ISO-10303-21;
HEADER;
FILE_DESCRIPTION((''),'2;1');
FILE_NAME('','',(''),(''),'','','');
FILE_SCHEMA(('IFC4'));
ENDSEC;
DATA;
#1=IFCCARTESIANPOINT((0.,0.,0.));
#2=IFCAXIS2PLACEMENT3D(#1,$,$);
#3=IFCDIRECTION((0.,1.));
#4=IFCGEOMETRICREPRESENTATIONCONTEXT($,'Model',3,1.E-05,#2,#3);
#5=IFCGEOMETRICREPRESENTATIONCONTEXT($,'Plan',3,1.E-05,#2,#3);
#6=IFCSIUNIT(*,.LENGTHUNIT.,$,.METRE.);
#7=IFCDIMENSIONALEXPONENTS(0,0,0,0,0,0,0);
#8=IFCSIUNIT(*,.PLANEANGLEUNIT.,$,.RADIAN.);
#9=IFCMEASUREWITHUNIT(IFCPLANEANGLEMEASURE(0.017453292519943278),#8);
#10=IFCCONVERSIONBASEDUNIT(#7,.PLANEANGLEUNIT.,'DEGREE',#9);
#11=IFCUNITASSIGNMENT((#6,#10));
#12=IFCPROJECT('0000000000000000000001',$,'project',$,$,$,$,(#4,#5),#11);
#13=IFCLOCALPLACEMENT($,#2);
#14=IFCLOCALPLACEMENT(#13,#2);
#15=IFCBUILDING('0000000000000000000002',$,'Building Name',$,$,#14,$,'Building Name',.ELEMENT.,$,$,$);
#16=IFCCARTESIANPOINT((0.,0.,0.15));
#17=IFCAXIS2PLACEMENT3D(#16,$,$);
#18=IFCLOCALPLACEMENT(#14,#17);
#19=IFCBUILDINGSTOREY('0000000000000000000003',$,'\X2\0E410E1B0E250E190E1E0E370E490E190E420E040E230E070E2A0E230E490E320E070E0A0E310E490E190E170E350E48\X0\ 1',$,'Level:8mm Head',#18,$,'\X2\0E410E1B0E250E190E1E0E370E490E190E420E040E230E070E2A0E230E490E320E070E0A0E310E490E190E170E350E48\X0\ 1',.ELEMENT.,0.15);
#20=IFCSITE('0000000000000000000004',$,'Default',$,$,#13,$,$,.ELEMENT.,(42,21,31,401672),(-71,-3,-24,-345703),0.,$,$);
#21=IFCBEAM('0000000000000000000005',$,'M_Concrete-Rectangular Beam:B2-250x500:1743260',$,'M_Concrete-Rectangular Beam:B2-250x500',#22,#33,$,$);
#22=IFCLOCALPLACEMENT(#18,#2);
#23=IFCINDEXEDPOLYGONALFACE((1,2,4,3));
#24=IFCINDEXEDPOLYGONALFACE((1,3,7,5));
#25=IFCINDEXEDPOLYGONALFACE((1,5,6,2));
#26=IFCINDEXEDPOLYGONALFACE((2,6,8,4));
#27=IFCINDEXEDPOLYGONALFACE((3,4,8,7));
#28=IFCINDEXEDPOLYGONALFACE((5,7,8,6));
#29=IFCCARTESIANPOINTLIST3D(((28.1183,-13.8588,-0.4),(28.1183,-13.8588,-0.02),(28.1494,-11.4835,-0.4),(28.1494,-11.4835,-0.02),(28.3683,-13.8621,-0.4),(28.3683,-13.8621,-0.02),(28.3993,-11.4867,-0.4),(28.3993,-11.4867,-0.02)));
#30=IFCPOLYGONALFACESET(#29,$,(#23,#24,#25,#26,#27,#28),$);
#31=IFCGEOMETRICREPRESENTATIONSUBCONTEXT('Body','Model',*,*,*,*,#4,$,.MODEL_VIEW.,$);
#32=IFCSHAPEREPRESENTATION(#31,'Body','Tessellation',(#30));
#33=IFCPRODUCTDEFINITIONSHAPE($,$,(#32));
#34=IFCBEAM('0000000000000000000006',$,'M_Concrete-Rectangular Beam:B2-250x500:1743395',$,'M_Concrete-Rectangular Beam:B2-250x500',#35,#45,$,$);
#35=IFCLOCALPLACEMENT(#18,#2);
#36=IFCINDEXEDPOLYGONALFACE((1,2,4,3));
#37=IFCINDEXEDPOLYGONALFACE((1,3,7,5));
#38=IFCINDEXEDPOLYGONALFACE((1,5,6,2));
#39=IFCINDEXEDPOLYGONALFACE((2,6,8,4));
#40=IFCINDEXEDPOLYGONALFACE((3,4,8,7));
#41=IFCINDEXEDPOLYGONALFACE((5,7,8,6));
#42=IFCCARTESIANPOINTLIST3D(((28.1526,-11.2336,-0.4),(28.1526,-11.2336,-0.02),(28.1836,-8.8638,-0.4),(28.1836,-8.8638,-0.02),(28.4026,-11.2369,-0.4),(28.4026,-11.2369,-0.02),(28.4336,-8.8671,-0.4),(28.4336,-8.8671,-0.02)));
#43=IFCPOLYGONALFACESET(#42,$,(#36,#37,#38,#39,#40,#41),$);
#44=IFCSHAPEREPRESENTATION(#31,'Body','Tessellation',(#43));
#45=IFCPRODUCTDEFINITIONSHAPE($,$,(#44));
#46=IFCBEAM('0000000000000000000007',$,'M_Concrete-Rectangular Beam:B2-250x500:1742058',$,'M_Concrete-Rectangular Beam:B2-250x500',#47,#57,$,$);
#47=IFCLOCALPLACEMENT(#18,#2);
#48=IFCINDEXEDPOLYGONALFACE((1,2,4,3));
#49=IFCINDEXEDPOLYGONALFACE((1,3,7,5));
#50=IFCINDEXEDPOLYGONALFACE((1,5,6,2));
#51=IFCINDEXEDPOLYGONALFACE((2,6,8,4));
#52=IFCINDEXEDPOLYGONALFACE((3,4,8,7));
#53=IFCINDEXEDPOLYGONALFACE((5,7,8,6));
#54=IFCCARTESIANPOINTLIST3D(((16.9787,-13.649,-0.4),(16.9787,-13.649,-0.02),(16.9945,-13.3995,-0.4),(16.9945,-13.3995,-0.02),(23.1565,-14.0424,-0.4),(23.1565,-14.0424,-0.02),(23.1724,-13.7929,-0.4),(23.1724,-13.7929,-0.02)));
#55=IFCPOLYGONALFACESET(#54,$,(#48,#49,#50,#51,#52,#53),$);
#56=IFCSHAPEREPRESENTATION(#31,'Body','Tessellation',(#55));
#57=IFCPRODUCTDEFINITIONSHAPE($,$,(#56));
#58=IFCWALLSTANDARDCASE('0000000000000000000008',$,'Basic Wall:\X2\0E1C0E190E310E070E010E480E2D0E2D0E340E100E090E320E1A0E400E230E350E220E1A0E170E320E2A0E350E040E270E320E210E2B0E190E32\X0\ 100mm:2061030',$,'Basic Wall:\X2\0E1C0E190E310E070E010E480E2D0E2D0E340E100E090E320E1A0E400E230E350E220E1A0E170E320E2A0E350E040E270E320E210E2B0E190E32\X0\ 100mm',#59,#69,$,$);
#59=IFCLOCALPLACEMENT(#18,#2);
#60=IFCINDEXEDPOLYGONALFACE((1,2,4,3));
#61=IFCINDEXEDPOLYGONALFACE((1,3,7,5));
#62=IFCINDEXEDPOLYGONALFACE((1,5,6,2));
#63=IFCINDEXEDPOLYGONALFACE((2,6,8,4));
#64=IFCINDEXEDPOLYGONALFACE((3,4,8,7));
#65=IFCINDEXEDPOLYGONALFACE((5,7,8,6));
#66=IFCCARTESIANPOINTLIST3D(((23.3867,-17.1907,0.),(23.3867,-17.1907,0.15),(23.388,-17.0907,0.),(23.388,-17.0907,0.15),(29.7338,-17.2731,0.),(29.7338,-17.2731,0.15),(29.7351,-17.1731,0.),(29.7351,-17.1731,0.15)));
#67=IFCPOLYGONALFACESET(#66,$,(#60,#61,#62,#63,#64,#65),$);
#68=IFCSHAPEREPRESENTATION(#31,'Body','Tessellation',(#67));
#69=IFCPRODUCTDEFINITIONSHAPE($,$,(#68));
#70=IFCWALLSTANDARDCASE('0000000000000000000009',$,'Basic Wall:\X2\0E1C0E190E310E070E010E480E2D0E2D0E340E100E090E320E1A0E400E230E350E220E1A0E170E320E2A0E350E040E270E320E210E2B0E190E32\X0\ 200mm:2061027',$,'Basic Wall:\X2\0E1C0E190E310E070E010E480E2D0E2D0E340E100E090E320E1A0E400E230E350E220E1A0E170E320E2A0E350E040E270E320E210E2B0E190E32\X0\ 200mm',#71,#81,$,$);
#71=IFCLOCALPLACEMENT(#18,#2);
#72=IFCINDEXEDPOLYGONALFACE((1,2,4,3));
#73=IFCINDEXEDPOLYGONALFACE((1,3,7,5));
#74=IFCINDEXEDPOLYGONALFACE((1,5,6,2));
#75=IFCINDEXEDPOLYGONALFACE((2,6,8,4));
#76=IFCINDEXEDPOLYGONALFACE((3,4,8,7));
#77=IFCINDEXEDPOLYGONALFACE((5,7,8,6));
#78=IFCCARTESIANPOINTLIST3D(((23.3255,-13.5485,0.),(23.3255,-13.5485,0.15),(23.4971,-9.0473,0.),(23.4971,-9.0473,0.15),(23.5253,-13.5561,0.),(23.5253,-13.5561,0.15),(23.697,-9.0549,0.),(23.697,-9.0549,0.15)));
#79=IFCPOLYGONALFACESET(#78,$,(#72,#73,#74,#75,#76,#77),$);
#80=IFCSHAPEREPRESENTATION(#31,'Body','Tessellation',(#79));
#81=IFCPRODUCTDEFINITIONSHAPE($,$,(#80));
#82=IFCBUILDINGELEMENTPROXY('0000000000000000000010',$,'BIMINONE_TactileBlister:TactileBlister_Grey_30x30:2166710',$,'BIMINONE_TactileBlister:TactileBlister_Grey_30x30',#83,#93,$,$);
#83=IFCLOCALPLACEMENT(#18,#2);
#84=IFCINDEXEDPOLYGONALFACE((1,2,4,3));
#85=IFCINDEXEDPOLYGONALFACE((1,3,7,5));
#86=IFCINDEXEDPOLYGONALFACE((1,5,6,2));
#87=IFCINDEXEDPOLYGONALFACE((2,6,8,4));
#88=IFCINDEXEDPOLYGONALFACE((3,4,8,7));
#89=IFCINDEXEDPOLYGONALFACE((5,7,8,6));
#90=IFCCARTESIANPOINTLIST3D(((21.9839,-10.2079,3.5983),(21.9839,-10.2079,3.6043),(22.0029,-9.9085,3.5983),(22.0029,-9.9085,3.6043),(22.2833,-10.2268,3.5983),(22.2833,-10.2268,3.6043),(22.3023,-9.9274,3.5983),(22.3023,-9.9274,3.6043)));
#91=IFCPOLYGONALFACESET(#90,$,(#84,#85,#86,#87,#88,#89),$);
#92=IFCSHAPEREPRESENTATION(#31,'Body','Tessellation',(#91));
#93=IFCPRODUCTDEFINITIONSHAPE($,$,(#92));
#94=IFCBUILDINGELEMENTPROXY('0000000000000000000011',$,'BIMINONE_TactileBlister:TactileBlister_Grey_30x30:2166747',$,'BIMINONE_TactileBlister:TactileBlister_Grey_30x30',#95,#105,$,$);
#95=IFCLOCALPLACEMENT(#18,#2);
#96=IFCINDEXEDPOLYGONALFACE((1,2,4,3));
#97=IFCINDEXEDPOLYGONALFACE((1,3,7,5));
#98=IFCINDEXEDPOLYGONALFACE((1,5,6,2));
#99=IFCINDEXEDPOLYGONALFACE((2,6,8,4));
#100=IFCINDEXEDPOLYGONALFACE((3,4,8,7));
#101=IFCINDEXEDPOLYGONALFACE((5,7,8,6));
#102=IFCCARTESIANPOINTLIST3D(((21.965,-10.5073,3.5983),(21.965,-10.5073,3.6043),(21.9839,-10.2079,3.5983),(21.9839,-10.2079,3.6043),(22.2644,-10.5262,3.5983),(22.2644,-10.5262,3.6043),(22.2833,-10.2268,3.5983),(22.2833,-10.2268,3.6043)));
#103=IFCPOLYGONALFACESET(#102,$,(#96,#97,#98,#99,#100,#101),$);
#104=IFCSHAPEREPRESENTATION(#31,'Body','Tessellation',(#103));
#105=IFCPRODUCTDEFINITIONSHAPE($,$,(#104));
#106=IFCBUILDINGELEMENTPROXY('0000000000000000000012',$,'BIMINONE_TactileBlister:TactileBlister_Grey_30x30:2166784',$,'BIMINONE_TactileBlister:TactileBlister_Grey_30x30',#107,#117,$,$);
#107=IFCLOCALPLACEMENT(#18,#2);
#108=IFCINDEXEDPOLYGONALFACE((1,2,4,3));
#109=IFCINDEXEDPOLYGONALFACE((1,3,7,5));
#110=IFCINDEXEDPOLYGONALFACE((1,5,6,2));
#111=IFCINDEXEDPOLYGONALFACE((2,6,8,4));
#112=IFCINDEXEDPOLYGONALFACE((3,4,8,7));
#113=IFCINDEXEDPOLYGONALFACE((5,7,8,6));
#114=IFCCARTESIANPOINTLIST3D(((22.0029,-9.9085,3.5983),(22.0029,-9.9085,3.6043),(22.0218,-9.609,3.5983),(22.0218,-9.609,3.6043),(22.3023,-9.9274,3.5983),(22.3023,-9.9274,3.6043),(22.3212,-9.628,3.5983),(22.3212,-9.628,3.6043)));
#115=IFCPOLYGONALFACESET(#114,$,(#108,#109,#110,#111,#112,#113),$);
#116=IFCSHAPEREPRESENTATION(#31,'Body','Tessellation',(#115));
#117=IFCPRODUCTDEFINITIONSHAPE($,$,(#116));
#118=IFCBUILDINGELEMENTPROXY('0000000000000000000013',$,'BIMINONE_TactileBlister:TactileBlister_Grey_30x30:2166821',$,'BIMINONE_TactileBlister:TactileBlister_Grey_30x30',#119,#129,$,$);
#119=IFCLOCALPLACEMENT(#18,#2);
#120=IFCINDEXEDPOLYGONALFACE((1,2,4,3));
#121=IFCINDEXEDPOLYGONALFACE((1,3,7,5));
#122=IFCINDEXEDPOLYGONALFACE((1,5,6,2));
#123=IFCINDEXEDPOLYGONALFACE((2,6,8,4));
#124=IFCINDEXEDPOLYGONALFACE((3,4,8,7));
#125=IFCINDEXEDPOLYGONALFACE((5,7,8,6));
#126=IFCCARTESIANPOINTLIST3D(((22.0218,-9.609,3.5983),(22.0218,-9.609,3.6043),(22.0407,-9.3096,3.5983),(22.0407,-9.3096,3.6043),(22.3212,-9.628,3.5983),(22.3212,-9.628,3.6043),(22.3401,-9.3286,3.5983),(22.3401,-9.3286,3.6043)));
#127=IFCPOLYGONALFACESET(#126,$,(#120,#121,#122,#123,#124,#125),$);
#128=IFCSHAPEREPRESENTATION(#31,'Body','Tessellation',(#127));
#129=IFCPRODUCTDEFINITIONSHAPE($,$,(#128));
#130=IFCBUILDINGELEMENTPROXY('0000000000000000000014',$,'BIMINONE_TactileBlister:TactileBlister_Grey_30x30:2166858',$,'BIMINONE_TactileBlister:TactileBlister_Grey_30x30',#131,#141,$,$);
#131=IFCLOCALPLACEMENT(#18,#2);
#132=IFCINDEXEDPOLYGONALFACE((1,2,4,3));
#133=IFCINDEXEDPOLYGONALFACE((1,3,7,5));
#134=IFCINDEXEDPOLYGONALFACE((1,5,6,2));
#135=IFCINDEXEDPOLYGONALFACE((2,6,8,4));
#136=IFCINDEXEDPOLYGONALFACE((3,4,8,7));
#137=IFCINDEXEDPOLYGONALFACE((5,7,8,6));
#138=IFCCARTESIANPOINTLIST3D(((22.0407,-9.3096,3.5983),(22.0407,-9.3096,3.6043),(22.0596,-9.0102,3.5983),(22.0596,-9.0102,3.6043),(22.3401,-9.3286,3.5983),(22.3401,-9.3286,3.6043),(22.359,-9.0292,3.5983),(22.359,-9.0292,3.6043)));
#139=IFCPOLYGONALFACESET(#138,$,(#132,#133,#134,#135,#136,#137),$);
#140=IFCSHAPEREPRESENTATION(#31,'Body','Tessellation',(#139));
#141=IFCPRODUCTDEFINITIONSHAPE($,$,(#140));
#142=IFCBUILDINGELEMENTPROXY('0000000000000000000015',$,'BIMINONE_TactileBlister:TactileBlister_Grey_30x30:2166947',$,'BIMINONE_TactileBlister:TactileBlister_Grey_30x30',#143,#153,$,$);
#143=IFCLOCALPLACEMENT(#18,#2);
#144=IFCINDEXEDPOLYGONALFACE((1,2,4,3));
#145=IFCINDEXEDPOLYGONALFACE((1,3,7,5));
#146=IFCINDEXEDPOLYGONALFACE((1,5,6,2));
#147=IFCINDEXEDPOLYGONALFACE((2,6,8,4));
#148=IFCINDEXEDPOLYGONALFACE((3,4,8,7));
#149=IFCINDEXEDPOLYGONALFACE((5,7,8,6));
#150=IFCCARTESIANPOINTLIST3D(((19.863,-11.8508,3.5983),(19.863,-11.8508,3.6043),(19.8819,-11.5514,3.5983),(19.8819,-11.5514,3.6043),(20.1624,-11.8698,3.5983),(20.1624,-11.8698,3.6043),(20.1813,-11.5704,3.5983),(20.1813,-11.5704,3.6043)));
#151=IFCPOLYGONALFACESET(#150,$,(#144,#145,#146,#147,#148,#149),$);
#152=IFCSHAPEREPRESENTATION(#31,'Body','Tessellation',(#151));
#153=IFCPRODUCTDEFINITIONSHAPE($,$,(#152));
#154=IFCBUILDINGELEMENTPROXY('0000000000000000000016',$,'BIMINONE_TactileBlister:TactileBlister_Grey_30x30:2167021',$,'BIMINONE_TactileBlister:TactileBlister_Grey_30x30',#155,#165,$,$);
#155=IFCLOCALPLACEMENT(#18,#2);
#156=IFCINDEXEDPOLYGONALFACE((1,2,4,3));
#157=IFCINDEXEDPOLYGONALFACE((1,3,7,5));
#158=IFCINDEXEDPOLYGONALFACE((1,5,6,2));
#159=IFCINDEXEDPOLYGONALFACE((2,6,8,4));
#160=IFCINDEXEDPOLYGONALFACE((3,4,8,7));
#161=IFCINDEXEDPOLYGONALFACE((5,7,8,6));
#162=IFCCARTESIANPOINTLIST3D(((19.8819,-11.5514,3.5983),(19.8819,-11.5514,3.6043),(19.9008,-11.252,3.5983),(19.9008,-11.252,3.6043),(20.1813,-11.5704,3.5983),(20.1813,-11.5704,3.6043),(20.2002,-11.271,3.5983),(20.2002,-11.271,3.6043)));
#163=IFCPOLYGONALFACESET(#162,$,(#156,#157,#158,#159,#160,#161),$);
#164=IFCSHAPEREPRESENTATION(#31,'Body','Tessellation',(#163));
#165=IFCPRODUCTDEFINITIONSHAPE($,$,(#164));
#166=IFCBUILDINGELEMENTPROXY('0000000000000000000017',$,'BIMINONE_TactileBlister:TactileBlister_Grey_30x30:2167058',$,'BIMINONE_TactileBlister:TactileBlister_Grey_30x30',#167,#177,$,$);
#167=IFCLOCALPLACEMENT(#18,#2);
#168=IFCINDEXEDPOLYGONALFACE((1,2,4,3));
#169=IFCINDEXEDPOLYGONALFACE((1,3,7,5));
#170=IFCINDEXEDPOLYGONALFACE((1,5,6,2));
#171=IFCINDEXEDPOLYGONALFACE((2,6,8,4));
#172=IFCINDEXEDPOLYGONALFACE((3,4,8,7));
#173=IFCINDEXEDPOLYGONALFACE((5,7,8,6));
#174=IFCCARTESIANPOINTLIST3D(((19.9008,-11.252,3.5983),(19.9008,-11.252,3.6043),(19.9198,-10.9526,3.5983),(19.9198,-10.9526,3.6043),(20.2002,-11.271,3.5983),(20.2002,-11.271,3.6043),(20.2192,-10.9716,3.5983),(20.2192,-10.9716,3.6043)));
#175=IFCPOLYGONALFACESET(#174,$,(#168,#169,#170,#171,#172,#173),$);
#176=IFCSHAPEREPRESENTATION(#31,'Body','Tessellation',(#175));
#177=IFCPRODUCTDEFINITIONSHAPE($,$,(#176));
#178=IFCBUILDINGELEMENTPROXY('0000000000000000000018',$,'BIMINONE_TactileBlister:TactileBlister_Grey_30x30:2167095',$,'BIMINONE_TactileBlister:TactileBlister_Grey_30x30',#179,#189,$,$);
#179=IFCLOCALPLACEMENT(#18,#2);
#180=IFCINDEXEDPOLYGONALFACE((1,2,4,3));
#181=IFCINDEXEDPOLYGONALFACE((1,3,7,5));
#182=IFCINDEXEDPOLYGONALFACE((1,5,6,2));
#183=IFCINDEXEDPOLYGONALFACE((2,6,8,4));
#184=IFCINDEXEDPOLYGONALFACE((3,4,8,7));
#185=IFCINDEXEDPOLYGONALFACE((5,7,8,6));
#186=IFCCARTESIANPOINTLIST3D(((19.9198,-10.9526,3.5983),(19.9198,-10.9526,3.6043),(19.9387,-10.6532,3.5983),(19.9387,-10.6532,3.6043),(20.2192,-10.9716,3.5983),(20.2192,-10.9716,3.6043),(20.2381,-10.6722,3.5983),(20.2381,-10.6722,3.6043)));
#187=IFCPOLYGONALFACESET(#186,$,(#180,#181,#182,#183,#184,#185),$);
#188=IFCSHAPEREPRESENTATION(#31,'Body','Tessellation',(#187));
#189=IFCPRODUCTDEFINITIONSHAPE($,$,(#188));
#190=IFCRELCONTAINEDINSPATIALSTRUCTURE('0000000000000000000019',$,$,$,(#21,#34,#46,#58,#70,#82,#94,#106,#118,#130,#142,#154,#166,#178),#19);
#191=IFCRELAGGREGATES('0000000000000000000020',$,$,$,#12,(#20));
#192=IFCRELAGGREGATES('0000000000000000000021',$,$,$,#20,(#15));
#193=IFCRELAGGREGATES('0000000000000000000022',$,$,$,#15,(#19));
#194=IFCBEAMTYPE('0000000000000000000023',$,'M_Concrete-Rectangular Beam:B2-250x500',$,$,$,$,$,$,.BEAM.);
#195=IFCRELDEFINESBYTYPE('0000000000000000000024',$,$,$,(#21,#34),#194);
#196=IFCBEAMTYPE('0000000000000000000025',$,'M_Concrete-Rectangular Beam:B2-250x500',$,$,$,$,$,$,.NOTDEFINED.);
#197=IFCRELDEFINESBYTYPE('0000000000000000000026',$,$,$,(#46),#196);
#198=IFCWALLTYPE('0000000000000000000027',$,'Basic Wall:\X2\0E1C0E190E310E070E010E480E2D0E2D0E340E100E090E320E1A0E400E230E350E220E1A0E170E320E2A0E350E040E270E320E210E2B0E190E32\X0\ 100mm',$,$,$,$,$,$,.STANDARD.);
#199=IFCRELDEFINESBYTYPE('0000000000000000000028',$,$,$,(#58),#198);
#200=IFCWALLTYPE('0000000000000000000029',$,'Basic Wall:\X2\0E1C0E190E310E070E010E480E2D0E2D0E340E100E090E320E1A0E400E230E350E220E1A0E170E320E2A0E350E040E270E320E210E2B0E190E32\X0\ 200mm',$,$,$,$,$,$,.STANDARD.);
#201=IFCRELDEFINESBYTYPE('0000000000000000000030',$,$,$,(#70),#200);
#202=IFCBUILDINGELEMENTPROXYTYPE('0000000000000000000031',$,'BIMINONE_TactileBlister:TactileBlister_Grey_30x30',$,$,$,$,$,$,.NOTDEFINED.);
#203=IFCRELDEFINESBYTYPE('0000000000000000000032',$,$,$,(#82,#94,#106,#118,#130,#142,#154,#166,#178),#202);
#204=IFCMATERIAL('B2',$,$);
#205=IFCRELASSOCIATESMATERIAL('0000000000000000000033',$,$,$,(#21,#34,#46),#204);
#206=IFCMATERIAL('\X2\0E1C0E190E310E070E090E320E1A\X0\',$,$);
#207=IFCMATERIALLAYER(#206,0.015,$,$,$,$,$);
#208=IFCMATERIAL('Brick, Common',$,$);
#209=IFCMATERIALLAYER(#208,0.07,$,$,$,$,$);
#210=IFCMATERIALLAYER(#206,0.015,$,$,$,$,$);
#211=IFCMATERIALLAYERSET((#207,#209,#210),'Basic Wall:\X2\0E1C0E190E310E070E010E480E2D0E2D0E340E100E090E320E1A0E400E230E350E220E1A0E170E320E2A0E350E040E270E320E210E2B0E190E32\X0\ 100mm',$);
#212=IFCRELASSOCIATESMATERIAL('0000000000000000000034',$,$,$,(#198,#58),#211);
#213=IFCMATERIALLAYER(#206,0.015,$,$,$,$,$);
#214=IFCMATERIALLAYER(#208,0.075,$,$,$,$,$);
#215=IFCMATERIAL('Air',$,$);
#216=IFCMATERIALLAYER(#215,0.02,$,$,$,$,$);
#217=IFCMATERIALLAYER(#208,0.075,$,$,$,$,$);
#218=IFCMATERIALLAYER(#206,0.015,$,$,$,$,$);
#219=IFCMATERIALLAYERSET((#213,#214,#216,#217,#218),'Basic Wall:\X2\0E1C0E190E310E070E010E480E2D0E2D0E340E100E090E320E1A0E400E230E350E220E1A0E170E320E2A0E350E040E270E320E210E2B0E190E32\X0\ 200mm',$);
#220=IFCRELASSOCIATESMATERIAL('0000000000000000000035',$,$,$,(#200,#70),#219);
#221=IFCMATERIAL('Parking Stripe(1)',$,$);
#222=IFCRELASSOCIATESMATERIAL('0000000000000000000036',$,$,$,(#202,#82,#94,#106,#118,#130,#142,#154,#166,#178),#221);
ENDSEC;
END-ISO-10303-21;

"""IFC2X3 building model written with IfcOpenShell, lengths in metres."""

from ifc_helpers import new_model, entity, si_unit, converted_unit, direction, frame, frame_2d, origin, origin_2d_with_axis, place, context, subcontext, project, spatial, rectangle, extrude, clip, halfspace, source, transform, mapped, material, layer, layer_set, layer_usage, type_object, type_shapes, element, save


model = new_model("IFC2X3")

# Units and contexts
model_context = context("Model", 3, precision=1e-05, world=origin(), true_north=direction((0.0, 1.0)))
plan_context = context("Plan", 3, precision=1e-05, world=origin(), true_north=direction((0.0, 1.0)))
body_context = subcontext(model_context, "Body", "Model", "MODEL_VIEW")
ifc_project = project(units=[si_unit("LENGTHUNIT", "METRE"), converted_unit("PLANEANGLEUNIT", "DEGREE", entity("IfcPlaneAngleMeasure", 0.017453292519943278), si_unit("PLANEANGLEUNIT", "RADIAN"), dimensions=[0, 0, 0, 0, 0, 0, 0])], contexts=[model_context, plan_context])

# Site, building, storey
site_placement = place(None, origin())
site = spatial("IfcSite", under=ifc_project, at=site_placement, Name="Default", CompositionType="ELEMENT", RefLatitude=(42, 21, 31, 401672), RefLongitude=(-71, -3, -24, -345703), RefElevation=0.0)
building_placement = place(site_placement, origin())
building = spatial("IfcBuilding", under=site, at=building_placement, Name="Building Name", LongName="Building Name", CompositionType="ELEMENT")
storey_placement = place(building_placement, frame((0.0, 0.0, 0.15)))
storey = spatial("IfcBuildingStorey", under=building, at=storey_placement, Name="แปลนพื้นโครงสร้างชั้นที่ 1", ObjectType="Level:8mm Head", LongName="แปลนพื้นโครงสร้างชั้นที่ 1", CompositionType="ELEMENT", Elevation=0.15)

# Beams
ifc_material_1 = material(Name="B2")
beam_type_1 = type_object("IfcBeamType", Name="M_Concrete-Rectangular Beam:B2-250x500", PredefinedType="BEAM")
beam_1_placement = place(storey_placement, frame((28.1183, -13.8588, 0.0), z_axis=(0.0, 0.0, 1.0), x_axis=(0.013073, 0.999915, 0.0)))
element("IfcBeam", 1, at=beam_1_placement, inside=storey, type_object=beam_type_1, material=ifc_material_1, Name="M_Concrete-Rectangular Beam:B2-250x500:1743260", ObjectType="M_Concrete-Rectangular Beam:B2-250x500", context=body_context, shape_type="SweptSolid", body=[
    extrude(rectangle(XDim=0.38, YDim=0.25, at=frame_2d((0.0, 0.0), x_axis=(1.0, 0.0))), frame((0.0, -0.125, -0.21), z_axis=(1.0, 0.0, 0.0), x_axis=(0.0, 0.0, -1.0)), (0.0, 0.0, 1.0), 2.3755),
])
beam_2_placement = place(storey_placement, frame((28.151, -11.3586, 0.0), z_axis=(0.0, 0.0, 1.0), x_axis=(0.013073, 0.999915, 0.0)))
element("IfcBeam", 2, at=beam_2_placement, inside=storey, type_object=beam_type_1, material=ifc_material_1, Name="M_Concrete-Rectangular Beam:B2-250x500:1743395", ObjectType="M_Concrete-Rectangular Beam:B2-250x500", context=body_context, shape_type="SweptSolid", body=[
    extrude(rectangle(XDim=0.38, YDim=0.25, at=frame_2d((0.0, 0.0), x_axis=(1.0, 0.0))), frame((0.125, -0.125, -0.21), z_axis=(1.0, 0.0, 0.0), x_axis=(0.0, 0.0, -1.0)), (0.0, 0.0, 1.0), 2.37),
])
beam_type_2 = type_object("IfcBeamType", Name="M_Concrete-Rectangular Beam:B2-250x500", PredefinedType="NOTDEFINED")
beam_3_placement = place(storey_placement, frame((23.1565, -14.0424, 0.0), z_axis=(0.0, 0.0, 1.0), x_axis=(-0.997978, 0.063562, 0.0)))
element("IfcBeam", 3, at=beam_3_placement, inside=storey, type_object=beam_type_2, material=ifc_material_1, Name="M_Concrete-Rectangular Beam:B2-250x500:1742058", ObjectType="M_Concrete-Rectangular Beam:B2-250x500", context=body_context, shape_type="SweptSolid", body=[
    extrude(rectangle(XDim=0.38, YDim=0.25, at=frame_2d((0.0, 0.0), x_axis=(1.0, 0.0))), frame((0.0, -0.125, -0.21), z_axis=(1.0, 0.0, 0.0), x_axis=(0.0, 0.0, -1.0)), (0.0, 0.0, 1.0), 6.1904),
])

# Walls
ifc_material_2 = material(Name="ผนังฉาบ")
ifc_layer_1 = layer(ifc_material_2, 0.015)
ifc_material_3 = material(Name="Brick, Common")
ifc_layer_2 = layer(ifc_material_3, 0.07)
ifc_layer_3 = layer(ifc_material_2, 0.015)
ifc_layer_set_1 = layer_set([ifc_layer_1, ifc_layer_2, ifc_layer_3], Name="Basic Wall:ผนังก่ออิฐฉาบเรียบทาสีความหนา 100mm")
ifc_layer_usage_1 = layer_usage(ifc_layer_set_1, "AXIS2", "POSITIVE", -0.05)
wall_type_1 = type_object("IfcWallType", Name="Basic Wall:ผนังก่ออิฐฉาบเรียบทาสีความหนา 100mm", PredefinedType="STANDARD", material=ifc_layer_set_1)
wall_1_placement = place(storey_placement, frame((23.3874, -17.1407, 0.0), z_axis=(0.0, 0.0, 1.0), x_axis=(0.999916, -0.012983, 0.0)))
element("IfcWallStandardCase", 4, at=wall_1_placement, inside=storey, type_object=wall_type_1, material=ifc_layer_usage_1, Name="Basic Wall:ผนังก่ออิฐฉาบเรียบทาสีความหนา 100mm:2061030", ObjectType="Basic Wall:ผนังก่ออิฐฉาบเรียบทาสีความหนา 100mm", context=body_context, shape_type="Clipping", body=[
    clip(extrude(rectangle(XDim=6.3476, YDim=0.1, at=frame_2d((3.1738, 0.0), x_axis=(-1.0, 0.0))), origin(), (0.0, 0.0, 1.0), 0.15), halfspace(origin(), True)),
])
ifc_layer_4 = layer(ifc_material_2, 0.015)
ifc_layer_5 = layer(ifc_material_3, 0.075)
ifc_material_4 = material(Name="Air")
ifc_layer_6 = layer(ifc_material_4, 0.02)
ifc_layer_7 = layer(ifc_material_3, 0.075)
ifc_layer_8 = layer(ifc_material_2, 0.015)
ifc_layer_set_2 = layer_set([ifc_layer_4, ifc_layer_5, ifc_layer_6, ifc_layer_7, ifc_layer_8], Name="Basic Wall:ผนังก่ออิฐฉาบเรียบทาสีความหนา 200mm")
ifc_layer_usage_2 = layer_usage(ifc_layer_set_2, "AXIS2", "POSITIVE", -0.1)
wall_type_2 = type_object("IfcWallType", Name="Basic Wall:ผนังก่ออิฐฉาบเรียบทาสีความหนา 200mm", PredefinedType="STANDARD", material=ifc_layer_set_2)
wall_2_placement = place(storey_placement, frame((23.4254, -13.5523, 0.0), z_axis=(0.0, 0.0, 1.0), x_axis=(0.038106, 0.999274, 0.0)))
element("IfcWallStandardCase", 5, at=wall_2_placement, inside=storey, type_object=wall_type_2, material=ifc_layer_usage_2, Name="Basic Wall:ผนังก่ออิฐฉาบเรียบทาสีความหนา 200mm:2061027", ObjectType="Basic Wall:ผนังก่ออิฐฉาบเรียบทาสีความหนา 200mm", context=body_context, shape_type="Clipping", body=[
    clip(extrude(rectangle(XDim=4.5045, YDim=0.2, at=frame_2d((2.2522, 0.0), x_axis=(-1.0, 0.0))), origin(), (0.0, 0.0, 1.0), 0.15), halfspace(origin(), True)),
])

# Building element proxies
ifc_material_5 = material(Name="Parking Stripe(1)")
building_element_proxy_type = type_object("IfcBuildingElementProxyType", Name="BIMINONE_TactileBlister:TactileBlister_Grey_30x30", PredefinedType="NOTDEFINED", material=ifc_material_5)
shared_shape = source(origin(), body_context, "Body", "SweptSolid", [
    extrude(rectangle(XDim=0.3, YDim=0.3, at=origin_2d_with_axis()), frame((0.15, -0.15, 0.0), z_axis=(0.0, 0.0, 1.0), x_axis=(-1.0, 0.0, 0.0)), (0.0, 0.0, 1.0), 0.006),
])
type_shapes(building_element_proxy_type, [shared_shape])
for number, where, z_axis, x_axis, name in (
    (6, (21.9839, -10.2079, 3.5983), (0.0, 0.0, 1.0), (0.063097, 0.998007, 0.0), "BIMINONE_TactileBlister:TactileBlister_Grey_30x30:2166710"),
    (7, (21.965, -10.5073, 3.5983), (0.0, 0.0, 1.0), (0.063097, 0.998007, 0.0), "BIMINONE_TactileBlister:TactileBlister_Grey_30x30:2166747"),
    (8, (22.0029, -9.9085, 3.5983), (0.0, 0.0, 1.0), (0.063097, 0.998007, 0.0), "BIMINONE_TactileBlister:TactileBlister_Grey_30x30:2166784"),
    (9, (22.0218, -9.609, 3.5983), (0.0, 0.0, 1.0), (0.063097, 0.998007, 0.0), "BIMINONE_TactileBlister:TactileBlister_Grey_30x30:2166821"),
    (10, (22.0407, -9.3096, 3.5983), (0.0, 0.0, 1.0), (0.063097, 0.998007, 0.0), "BIMINONE_TactileBlister:TactileBlister_Grey_30x30:2166858"),
    (11, (19.863, -11.8508, 3.5983), (0.0, 0.0, 1.0), (0.063097, 0.998007, 0.0), "BIMINONE_TactileBlister:TactileBlister_Grey_30x30:2166947"),
    (12, (19.8819, -11.5514, 3.5983), (0.0, 0.0, 1.0), (0.063097, 0.998007, 0.0), "BIMINONE_TactileBlister:TactileBlister_Grey_30x30:2167021"),
    (13, (19.9008, -11.252, 3.5983), (0.0, 0.0, 1.0), (0.063097, 0.998007, 0.0), "BIMINONE_TactileBlister:TactileBlister_Grey_30x30:2167058"),
    (14, (19.9198, -10.9526, 3.5983), (0.0, 0.0, 1.0), (0.063097, 0.998007, 0.0), "BIMINONE_TactileBlister:TactileBlister_Grey_30x30:2167095"),
):
    element("IfcBuildingElementProxy", number, at=place(storey_placement, frame(where, z_axis=z_axis, x_axis=x_axis)), inside=storey, type_object=building_element_proxy_type, material=ifc_material_5, Name=name, ObjectType="BIMINONE_TactileBlister:TactileBlister_Grey_30x30", context=body_context, shape_type="MappedRepresentation", body=[
        mapped(shared_shape, transform((0.0, 0.0, 0.0), scale=1.0)),
    ])

save(model, "model.ifc")
